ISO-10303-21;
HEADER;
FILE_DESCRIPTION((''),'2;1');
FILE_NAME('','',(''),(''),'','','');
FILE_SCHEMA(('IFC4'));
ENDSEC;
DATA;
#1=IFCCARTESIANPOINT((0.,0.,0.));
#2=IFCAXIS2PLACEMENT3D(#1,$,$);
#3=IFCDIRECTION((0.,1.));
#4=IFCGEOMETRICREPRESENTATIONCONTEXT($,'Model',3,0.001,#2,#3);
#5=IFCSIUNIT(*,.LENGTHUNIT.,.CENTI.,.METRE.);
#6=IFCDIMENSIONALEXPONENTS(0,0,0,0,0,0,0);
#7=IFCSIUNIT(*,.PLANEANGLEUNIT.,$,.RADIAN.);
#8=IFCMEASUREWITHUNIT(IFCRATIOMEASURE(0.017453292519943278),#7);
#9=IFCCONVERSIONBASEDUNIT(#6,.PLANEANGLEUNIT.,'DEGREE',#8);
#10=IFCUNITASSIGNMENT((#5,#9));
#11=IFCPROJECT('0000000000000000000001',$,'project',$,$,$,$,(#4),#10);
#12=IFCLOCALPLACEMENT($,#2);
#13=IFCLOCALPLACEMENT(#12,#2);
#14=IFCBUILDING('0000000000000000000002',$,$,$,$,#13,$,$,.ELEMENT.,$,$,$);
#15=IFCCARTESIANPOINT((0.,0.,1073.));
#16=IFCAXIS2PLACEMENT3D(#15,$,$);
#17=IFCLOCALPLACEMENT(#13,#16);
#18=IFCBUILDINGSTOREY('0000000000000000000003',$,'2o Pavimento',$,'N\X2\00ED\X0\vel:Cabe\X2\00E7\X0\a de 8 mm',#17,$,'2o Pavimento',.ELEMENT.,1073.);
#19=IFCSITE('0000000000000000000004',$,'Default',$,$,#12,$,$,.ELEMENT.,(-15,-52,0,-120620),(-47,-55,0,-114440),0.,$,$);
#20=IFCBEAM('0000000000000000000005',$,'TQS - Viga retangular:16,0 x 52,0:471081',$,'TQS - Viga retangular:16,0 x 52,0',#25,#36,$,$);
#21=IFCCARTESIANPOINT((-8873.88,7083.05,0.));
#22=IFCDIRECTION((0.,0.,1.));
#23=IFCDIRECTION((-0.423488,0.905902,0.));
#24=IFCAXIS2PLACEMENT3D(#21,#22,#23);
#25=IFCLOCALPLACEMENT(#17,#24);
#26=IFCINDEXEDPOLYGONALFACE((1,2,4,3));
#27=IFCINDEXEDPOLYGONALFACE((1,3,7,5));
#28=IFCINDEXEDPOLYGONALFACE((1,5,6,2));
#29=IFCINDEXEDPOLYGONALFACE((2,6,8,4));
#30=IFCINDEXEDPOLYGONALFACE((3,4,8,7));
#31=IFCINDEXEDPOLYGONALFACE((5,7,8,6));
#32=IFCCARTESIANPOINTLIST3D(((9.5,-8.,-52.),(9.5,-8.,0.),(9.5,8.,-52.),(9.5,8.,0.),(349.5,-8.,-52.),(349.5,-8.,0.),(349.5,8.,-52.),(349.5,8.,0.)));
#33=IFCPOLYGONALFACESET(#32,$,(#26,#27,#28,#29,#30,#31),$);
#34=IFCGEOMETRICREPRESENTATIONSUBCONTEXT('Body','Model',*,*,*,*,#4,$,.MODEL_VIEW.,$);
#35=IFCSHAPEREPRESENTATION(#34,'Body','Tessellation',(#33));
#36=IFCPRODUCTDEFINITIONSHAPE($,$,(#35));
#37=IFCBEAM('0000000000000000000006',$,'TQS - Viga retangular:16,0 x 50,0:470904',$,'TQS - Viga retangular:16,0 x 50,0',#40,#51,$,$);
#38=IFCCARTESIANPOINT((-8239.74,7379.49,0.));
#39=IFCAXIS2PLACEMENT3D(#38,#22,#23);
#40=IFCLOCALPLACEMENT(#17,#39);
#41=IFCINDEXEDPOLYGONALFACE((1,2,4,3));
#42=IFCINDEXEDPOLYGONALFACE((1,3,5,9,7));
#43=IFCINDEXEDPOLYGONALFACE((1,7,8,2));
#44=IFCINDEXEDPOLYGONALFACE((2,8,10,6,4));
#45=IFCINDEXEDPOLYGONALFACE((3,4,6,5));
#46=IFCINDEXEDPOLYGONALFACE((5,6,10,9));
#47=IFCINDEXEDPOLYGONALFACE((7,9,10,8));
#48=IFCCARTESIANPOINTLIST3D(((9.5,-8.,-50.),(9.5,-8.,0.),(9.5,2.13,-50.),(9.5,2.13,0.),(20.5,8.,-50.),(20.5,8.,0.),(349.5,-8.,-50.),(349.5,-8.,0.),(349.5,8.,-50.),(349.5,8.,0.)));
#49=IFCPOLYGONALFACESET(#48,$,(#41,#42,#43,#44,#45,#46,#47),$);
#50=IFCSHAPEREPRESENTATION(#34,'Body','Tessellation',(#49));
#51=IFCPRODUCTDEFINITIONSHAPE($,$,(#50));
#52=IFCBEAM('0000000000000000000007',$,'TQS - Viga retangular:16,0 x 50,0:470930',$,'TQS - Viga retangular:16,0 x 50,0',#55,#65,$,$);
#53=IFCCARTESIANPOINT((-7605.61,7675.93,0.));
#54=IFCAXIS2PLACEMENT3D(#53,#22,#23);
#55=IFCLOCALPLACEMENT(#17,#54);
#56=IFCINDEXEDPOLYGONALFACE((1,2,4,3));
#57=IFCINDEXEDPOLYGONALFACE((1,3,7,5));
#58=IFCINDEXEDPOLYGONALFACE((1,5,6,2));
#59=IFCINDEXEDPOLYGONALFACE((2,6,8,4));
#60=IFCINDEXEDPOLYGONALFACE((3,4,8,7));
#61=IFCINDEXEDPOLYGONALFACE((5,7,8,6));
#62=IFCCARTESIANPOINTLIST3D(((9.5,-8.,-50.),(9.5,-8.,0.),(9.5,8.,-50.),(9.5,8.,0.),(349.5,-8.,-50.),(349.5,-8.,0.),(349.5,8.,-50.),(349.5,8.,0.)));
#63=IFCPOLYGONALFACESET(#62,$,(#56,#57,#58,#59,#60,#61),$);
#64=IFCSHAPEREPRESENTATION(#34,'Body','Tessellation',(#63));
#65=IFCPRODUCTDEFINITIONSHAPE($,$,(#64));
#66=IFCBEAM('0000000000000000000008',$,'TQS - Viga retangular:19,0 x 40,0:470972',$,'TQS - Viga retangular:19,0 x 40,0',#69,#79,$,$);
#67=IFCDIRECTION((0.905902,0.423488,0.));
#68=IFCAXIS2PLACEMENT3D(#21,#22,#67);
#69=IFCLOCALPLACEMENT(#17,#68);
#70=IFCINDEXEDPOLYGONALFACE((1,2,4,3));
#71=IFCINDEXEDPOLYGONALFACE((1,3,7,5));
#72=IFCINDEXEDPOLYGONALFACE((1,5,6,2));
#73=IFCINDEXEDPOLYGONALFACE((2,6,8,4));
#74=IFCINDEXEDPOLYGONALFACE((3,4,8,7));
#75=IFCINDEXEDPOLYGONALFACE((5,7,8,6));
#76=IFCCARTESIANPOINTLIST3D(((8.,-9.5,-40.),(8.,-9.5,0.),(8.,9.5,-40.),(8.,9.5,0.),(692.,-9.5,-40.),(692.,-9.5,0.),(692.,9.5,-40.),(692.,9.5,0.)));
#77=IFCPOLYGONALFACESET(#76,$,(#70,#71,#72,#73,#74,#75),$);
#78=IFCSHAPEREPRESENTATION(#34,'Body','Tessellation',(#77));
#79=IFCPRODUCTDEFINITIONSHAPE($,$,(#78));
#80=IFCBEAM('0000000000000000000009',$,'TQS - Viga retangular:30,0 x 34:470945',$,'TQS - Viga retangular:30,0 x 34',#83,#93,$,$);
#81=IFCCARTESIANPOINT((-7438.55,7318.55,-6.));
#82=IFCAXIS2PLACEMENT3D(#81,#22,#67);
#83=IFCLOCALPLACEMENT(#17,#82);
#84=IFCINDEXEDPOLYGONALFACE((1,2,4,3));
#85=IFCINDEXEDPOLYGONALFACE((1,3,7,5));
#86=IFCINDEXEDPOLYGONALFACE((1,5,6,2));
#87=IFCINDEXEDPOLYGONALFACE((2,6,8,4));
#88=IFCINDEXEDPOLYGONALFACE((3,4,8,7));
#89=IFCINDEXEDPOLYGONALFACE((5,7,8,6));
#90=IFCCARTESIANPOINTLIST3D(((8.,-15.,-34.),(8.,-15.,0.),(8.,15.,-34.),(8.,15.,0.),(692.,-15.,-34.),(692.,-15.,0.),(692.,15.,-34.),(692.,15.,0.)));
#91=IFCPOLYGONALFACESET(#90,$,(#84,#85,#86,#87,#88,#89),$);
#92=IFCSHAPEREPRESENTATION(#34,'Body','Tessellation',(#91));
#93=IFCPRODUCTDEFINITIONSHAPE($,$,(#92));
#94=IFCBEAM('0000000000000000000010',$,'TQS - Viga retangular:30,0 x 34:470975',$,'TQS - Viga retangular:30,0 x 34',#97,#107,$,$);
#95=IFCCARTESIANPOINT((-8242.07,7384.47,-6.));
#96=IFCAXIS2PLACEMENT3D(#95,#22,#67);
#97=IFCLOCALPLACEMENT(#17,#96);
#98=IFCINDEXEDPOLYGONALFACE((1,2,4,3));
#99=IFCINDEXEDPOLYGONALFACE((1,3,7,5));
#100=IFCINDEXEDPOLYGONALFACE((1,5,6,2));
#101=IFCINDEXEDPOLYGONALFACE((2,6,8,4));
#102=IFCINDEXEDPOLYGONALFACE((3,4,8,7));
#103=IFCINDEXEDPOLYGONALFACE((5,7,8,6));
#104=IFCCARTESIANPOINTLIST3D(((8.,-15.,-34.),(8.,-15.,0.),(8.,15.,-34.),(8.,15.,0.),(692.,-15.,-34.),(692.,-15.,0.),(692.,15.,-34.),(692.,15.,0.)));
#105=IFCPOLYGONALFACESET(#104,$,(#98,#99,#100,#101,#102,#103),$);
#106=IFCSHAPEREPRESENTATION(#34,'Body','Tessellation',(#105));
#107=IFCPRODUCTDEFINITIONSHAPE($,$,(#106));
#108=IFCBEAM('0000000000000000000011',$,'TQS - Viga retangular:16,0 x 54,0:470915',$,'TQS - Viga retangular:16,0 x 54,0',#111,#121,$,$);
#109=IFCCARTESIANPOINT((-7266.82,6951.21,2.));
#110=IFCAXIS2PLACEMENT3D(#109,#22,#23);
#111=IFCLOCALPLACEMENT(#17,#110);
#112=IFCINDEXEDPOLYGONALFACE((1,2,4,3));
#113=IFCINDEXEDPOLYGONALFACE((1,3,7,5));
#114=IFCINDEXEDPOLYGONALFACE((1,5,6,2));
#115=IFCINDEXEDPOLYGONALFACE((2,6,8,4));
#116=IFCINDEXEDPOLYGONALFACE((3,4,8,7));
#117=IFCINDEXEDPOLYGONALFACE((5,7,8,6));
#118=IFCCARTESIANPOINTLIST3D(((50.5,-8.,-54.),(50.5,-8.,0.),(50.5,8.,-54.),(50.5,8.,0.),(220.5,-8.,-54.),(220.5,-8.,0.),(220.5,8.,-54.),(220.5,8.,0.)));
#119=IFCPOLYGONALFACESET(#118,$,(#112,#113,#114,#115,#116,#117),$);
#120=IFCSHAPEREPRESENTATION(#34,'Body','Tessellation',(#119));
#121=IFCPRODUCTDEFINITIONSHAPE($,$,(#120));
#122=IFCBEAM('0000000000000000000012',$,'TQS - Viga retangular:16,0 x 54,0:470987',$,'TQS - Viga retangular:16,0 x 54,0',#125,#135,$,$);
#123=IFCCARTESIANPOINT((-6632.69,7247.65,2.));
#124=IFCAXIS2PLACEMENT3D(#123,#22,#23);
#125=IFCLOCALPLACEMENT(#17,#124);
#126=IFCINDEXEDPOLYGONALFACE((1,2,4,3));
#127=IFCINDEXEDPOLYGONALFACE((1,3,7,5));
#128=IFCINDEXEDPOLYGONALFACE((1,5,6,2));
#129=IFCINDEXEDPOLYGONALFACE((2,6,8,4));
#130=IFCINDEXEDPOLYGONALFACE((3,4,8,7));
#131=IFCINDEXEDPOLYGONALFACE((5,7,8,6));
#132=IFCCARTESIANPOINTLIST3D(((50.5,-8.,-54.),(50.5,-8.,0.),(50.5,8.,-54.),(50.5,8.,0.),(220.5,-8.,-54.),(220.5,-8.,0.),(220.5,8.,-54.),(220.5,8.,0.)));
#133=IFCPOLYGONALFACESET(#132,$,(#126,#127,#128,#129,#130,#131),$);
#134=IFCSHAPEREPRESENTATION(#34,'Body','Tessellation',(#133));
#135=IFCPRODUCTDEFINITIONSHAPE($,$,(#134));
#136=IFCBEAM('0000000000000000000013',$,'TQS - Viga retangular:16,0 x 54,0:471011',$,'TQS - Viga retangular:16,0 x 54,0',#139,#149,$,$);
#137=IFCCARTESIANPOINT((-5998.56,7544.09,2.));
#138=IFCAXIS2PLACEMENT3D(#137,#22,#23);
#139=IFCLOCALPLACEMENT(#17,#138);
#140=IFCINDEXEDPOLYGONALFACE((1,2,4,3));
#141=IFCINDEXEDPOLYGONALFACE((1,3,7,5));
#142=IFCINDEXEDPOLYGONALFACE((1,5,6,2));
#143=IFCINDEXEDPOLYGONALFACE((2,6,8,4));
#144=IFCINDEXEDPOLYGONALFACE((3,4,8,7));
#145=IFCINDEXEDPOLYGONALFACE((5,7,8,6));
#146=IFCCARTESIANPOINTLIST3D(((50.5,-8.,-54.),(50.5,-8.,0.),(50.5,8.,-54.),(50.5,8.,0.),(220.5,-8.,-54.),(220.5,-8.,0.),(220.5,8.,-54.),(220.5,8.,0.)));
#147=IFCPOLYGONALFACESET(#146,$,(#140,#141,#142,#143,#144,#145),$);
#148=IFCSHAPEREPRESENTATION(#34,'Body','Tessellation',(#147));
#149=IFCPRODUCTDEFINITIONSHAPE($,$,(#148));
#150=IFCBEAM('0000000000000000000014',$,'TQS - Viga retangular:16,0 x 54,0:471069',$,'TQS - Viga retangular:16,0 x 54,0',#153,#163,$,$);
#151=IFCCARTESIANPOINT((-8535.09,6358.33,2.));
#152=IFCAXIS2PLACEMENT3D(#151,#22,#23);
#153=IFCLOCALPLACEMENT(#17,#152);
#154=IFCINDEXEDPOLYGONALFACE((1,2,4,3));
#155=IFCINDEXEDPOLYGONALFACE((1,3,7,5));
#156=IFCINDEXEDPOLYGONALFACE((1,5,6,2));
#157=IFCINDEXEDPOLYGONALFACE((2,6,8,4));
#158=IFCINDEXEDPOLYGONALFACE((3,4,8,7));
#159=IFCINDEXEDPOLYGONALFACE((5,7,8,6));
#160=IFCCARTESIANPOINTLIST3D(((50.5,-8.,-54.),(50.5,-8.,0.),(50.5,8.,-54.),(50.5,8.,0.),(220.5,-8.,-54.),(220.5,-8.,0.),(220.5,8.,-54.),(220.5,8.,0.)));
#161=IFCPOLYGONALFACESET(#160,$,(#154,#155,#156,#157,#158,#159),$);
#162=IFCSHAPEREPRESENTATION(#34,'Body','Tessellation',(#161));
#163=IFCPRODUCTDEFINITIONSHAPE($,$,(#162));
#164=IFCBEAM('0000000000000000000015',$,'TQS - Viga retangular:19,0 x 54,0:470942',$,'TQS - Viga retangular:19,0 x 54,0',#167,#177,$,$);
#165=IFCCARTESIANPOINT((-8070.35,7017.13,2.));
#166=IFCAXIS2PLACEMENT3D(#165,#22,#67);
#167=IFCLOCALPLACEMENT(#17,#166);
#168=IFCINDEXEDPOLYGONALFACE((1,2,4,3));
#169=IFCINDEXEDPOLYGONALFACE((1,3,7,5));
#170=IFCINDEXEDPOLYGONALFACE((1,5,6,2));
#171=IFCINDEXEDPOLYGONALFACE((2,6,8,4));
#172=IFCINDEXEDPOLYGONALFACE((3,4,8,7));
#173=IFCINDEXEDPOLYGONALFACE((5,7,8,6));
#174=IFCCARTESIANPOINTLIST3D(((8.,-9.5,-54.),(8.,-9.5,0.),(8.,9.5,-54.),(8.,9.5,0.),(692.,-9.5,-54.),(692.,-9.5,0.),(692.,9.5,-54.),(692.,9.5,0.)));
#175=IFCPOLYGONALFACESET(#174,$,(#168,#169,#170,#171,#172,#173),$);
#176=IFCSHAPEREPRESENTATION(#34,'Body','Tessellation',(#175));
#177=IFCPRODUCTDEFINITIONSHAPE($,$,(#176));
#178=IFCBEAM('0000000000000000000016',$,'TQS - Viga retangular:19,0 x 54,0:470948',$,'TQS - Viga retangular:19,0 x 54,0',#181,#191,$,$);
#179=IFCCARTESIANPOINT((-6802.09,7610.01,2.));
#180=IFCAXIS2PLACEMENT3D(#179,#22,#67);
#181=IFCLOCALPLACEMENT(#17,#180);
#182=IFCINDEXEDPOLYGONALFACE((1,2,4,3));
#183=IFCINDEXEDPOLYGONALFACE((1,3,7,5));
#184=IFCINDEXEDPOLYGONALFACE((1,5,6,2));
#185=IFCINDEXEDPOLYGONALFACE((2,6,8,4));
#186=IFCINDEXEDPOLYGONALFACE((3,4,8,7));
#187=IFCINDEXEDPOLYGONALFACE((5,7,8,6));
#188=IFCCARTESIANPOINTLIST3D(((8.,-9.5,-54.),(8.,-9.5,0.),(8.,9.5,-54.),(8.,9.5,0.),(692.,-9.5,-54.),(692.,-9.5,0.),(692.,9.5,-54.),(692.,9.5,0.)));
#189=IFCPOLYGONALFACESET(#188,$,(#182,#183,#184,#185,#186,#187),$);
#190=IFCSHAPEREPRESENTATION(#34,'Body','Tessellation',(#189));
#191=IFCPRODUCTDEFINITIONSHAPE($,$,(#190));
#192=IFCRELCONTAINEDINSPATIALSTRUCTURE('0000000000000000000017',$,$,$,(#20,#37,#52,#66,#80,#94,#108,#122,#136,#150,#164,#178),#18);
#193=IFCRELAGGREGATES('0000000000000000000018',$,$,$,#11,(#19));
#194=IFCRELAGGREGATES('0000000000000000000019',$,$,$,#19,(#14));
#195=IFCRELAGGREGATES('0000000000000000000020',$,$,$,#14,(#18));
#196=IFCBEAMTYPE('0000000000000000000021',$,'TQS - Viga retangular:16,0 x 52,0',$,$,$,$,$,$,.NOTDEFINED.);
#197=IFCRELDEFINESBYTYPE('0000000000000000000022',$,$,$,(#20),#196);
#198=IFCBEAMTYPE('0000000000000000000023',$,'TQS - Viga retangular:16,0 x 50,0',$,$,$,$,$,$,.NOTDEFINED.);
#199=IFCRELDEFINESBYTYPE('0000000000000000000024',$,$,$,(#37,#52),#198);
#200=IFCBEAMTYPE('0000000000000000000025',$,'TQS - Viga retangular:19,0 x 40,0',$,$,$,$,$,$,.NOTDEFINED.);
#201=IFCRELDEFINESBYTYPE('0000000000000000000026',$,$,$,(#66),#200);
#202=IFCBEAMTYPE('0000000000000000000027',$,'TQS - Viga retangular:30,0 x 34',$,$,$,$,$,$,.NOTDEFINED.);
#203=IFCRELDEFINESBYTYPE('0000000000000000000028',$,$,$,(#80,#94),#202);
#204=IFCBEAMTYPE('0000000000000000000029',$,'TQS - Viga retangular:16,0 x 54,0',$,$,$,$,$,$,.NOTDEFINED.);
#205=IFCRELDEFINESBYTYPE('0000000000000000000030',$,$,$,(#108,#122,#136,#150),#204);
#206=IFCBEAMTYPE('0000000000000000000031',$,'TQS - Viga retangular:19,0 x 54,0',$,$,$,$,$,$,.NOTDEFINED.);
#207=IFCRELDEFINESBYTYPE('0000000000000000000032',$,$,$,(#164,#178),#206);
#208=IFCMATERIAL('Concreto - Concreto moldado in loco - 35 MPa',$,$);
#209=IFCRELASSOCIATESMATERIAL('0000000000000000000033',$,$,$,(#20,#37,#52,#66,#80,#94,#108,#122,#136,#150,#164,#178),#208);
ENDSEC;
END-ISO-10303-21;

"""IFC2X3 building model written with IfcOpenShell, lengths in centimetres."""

from ifc_helpers import new_model, entity, si_unit, converted_unit, direction, frame, frame_2d, origin, place, context, subcontext, project, spatial, rectangle, extrude, clip, halfspace, material, type_object, element, save


model = new_model("IFC2X3")

# Units and contexts
model_context = context("Model", 3, precision=0.001, world=origin(), true_north=direction((0.0, 1.0)))
body_context = subcontext(model_context, "Body", "Model", "MODEL_VIEW")
ifc_project = project(units=[si_unit("LENGTHUNIT", "METRE", prefix="CENTI"), converted_unit("PLANEANGLEUNIT", "DEGREE", entity("IfcRatioMeasure", 0.017453292519943278), si_unit("PLANEANGLEUNIT", "RADIAN"), dimensions=[0, 0, 0, 0, 0, 0, 0])], contexts=[model_context])

# Site, building, storey
site_placement = place(None, origin())
site = spatial("IfcSite", under=ifc_project, at=site_placement, Name="Default", CompositionType="ELEMENT", RefLatitude=(-15, -52, 0, -120620), RefLongitude=(-47, -55, 0, -114440), RefElevation=0.0)
building_placement = place(site_placement, origin())
building = spatial("IfcBuilding", under=site, at=building_placement, CompositionType="ELEMENT")
storey_placement = place(building_placement, frame((0.0, 0.0, 1073.0)))
storey = spatial("IfcBuildingStorey", under=building, at=storey_placement, Name="2o Pavimento", ObjectType="Nível:Cabeça de 8 mm", LongName="2o Pavimento", CompositionType="ELEMENT", Elevation=1073.0)

# Beams
ifc_material_1 = material(Name="Concreto - Concreto moldado in loco - 35 MPa")
beam_type_1 = type_object("IfcBeamType", Name="TQS - Viga retangular:16,0 x 52,0", PredefinedType="NOTDEFINED")
beam_1_placement = place(storey_placement, frame((-8873.88, 7083.05, 0.0), z_axis=(0.0, 0.0, 1.0), x_axis=(-0.423488, 0.905902, 0.0)))
element("IfcBeam", 1, at=beam_1_placement, inside=storey, type_object=beam_type_1, material=ifc_material_1, Name="TQS - Viga retangular:16,0 x 52,0:471081", ObjectType="TQS - Viga retangular:16,0 x 52,0", context=body_context, shape_type="SweptSolid", body=[
    extrude(rectangle(XDim=52.0, YDim=16.0, at=frame_2d((0.0, 0.0), x_axis=(1.0, 0.0))), frame((9.5, 0.0, -26.0), z_axis=(1.0, 0.0, 0.0), x_axis=(0.0, 0.0, -1.0)), (0.0, 0.0, 1.0), 340.0),
])
beam_type_2 = type_object("IfcBeamType", Name="TQS - Viga retangular:16,0 x 50,0", PredefinedType="NOTDEFINED")
beam_2_placement = place(storey_placement, frame((-8239.74, 7379.49, 0.0), z_axis=(0.0, 0.0, 1.0), x_axis=(-0.423488, 0.905902, 0.0)))
element("IfcBeam", 2, at=beam_2_placement, inside=storey, type_object=beam_type_2, material=ifc_material_1, Name="TQS - Viga retangular:16,0 x 50,0:470904", ObjectType="TQS - Viga retangular:16,0 x 50,0", context=body_context, shape_type="SweptSolid", body=[
    clip(extrude(rectangle(XDim=50.0, YDim=16.0, at=frame_2d((0.0, 0.0), x_axis=(1.0, 0.0))), frame((9.5, 0.0, -25.0), z_axis=(1.0, 0.0, 0.0), x_axis=(0.0, 0.0, -1.0)), (0.0, 0.0, 1.0), 340.0), halfspace(frame((-9.5, -8.0, 0.0), z_axis=(-0.470588, 0.882353, 0.0), x_axis=(-0.882353, -0.470588, 0.0)), False)),
])
beam_3_placement = place(storey_placement, frame((-7605.61, 7675.93, 0.0), z_axis=(0.0, 0.0, 1.0), x_axis=(-0.423488, 0.905902, 0.0)))
element("IfcBeam", 3, at=beam_3_placement, inside=storey, type_object=beam_type_2, material=ifc_material_1, Name="TQS - Viga retangular:16,0 x 50,0:470930", ObjectType="TQS - Viga retangular:16,0 x 50,0", context=body_context, shape_type="SweptSolid", body=[
    extrude(rectangle(XDim=50.0, YDim=16.0, at=frame_2d((0.0, 0.0), x_axis=(1.0, 0.0))), frame((9.5, 0.0, -25.0), z_axis=(1.0, 0.0, 0.0), x_axis=(0.0, 0.0, -1.0)), (0.0, 0.0, 1.0), 340.0),
])
beam_type_3 = type_object("IfcBeamType", Name="TQS - Viga retangular:19,0 x 40,0", PredefinedType="NOTDEFINED")
beam_4_placement = place(storey_placement, frame((-8873.88, 7083.05, 0.0), z_axis=(0.0, 0.0, 1.0), x_axis=(0.905902, 0.423488, 0.0)))
element("IfcBeam", 4, at=beam_4_placement, inside=storey, type_object=beam_type_3, material=ifc_material_1, Name="TQS - Viga retangular:19,0 x 40,0:470972", ObjectType="TQS - Viga retangular:19,0 x 40,0", context=body_context, shape_type="SweptSolid", body=[
    extrude(rectangle(XDim=40.0, YDim=19.0, at=frame_2d((0.0, 0.0), x_axis=(1.0, 0.0))), frame((8.0, 0.0, -20.0), z_axis=(1.0, 0.0, 0.0), x_axis=(0.0, 0.0, -1.0)), (0.0, 0.0, 1.0), 684.0),
])
beam_type_4 = type_object("IfcBeamType", Name="TQS - Viga retangular:30,0 x 34", PredefinedType="NOTDEFINED")
beam_5_placement = place(storey_placement, frame((-7438.55, 7318.55, -6.0), z_axis=(0.0, 0.0, 1.0), x_axis=(0.905902, 0.423488, 0.0)))
element("IfcBeam", 5, at=beam_5_placement, inside=storey, type_object=beam_type_4, material=ifc_material_1, Name="TQS - Viga retangular:30,0 x 34:470945", ObjectType="TQS - Viga retangular:30,0 x 34", context=body_context, shape_type="SweptSolid", body=[
    extrude(rectangle(XDim=34.0, YDim=30.0, at=frame_2d((0.0, 0.0), x_axis=(1.0, 0.0))), frame((8.0, 0.0, -17.0), z_axis=(1.0, 0.0, 0.0), x_axis=(0.0, 0.0, -1.0)), (0.0, 0.0, 1.0), 684.0),
])
beam_6_placement = place(storey_placement, frame((-8242.07, 7384.47, -6.0), z_axis=(0.0, 0.0, 1.0), x_axis=(0.905902, 0.423488, 0.0)))
element("IfcBeam", 6, at=beam_6_placement, inside=storey, type_object=beam_type_4, material=ifc_material_1, Name="TQS - Viga retangular:30,0 x 34:470975", ObjectType="TQS - Viga retangular:30,0 x 34", context=body_context, shape_type="SweptSolid", body=[
    extrude(rectangle(XDim=34.0, YDim=30.0, at=frame_2d((0.0, 0.0), x_axis=(1.0, 0.0))), frame((8.0, 0.0, -17.0), z_axis=(1.0, 0.0, 0.0), x_axis=(0.0, 0.0, -1.0)), (0.0, 0.0, 1.0), 684.0),
])
beam_type_5 = type_object("IfcBeamType", Name="TQS - Viga retangular:16,0 x 54,0", PredefinedType="NOTDEFINED")
beam_7_placement = place(storey_placement, frame((-7266.82, 6951.21, 2.0), z_axis=(0.0, 0.0, 1.0), x_axis=(-0.423488, 0.905902, 0.0)))
element("IfcBeam", 7, at=beam_7_placement, inside=storey, type_object=beam_type_5, material=ifc_material_1, Name="TQS - Viga retangular:16,0 x 54,0:470915", ObjectType="TQS - Viga retangular:16,0 x 54,0", context=body_context, shape_type="SweptSolid", body=[
    extrude(rectangle(XDim=54.0, YDim=16.0, at=frame_2d((0.0, 0.0), x_axis=(1.0, 0.0))), frame((50.5, 0.0, -27.0), z_axis=(1.0, 0.0, 0.0), x_axis=(0.0, 0.0, -1.0)), (0.0, 0.0, 1.0), 170.0),
])
beam_8_placement = place(storey_placement, frame((-6632.69, 7247.65, 2.0), z_axis=(0.0, 0.0, 1.0), x_axis=(-0.423488, 0.905902, 0.0)))
element("IfcBeam", 8, at=beam_8_placement, inside=storey, type_object=beam_type_5, material=ifc_material_1, Name="TQS - Viga retangular:16,0 x 54,0:470987", ObjectType="TQS - Viga retangular:16,0 x 54,0", context=body_context, shape_type="SweptSolid", body=[
    extrude(rectangle(XDim=54.0, YDim=16.0, at=frame_2d((0.0, 0.0), x_axis=(1.0, 0.0))), frame((50.5, 0.0, -27.0), z_axis=(1.0, 0.0, 0.0), x_axis=(0.0, 0.0, -1.0)), (0.0, 0.0, 1.0), 170.0),
])
beam_9_placement = place(storey_placement, frame((-5998.56, 7544.09, 2.0), z_axis=(0.0, 0.0, 1.0), x_axis=(-0.423488, 0.905902, 0.0)))
element("IfcBeam", 9, at=beam_9_placement, inside=storey, type_object=beam_type_5, material=ifc_material_1, Name="TQS - Viga retangular:16,0 x 54,0:471011", ObjectType="TQS - Viga retangular:16,0 x 54,0", context=body_context, shape_type="SweptSolid", body=[
    extrude(rectangle(XDim=54.0, YDim=16.0, at=frame_2d((0.0, 0.0), x_axis=(1.0, 0.0))), frame((50.5, 0.0, -27.0), z_axis=(1.0, 0.0, 0.0), x_axis=(0.0, 0.0, -1.0)), (0.0, 0.0, 1.0), 170.0),
])
beam_10_placement = place(storey_placement, frame((-8535.09, 6358.33, 2.0), z_axis=(0.0, 0.0, 1.0), x_axis=(-0.423488, 0.905902, 0.0)))
element("IfcBeam", 10, at=beam_10_placement, inside=storey, type_object=beam_type_5, material=ifc_material_1, Name="TQS - Viga retangular:16,0 x 54,0:471069", ObjectType="TQS - Viga retangular:16,0 x 54,0", context=body_context, shape_type="SweptSolid", body=[
    extrude(rectangle(XDim=54.0, YDim=16.0, at=frame_2d((0.0, 0.0), x_axis=(1.0, 0.0))), frame((50.5, 0.0, -27.0), z_axis=(1.0, 0.0, 0.0), x_axis=(0.0, 0.0, -1.0)), (0.0, 0.0, 1.0), 170.0),
])
beam_type_6 = type_object("IfcBeamType", Name="TQS - Viga retangular:19,0 x 54,0", PredefinedType="NOTDEFINED")
beam_11_placement = place(storey_placement, frame((-8070.35, 7017.13, 2.0), z_axis=(0.0, 0.0, 1.0), x_axis=(0.905902, 0.423488, 0.0)))
element("IfcBeam", 11, at=beam_11_placement, inside=storey, type_object=beam_type_6, material=ifc_material_1, Name="TQS - Viga retangular:19,0 x 54,0:470942", ObjectType="TQS - Viga retangular:19,0 x 54,0", context=body_context, shape_type="SweptSolid", body=[
    extrude(rectangle(XDim=54.0, YDim=19.0, at=frame_2d((0.0, 0.0), x_axis=(1.0, 0.0))), frame((8.0, 0.0, -27.0), z_axis=(1.0, 0.0, 0.0), x_axis=(0.0, 0.0, -1.0)), (0.0, 0.0, 1.0), 684.0),
])
beam_12_placement = place(storey_placement, frame((-6802.09, 7610.01, 2.0), z_axis=(0.0, 0.0, 1.0), x_axis=(0.905902, 0.423488, 0.0)))
element("IfcBeam", 12, at=beam_12_placement, inside=storey, type_object=beam_type_6, material=ifc_material_1, Name="TQS - Viga retangular:19,0 x 54,0:470948", ObjectType="TQS - Viga retangular:19,0 x 54,0", context=body_context, shape_type="SweptSolid", body=[
    extrude(rectangle(XDim=54.0, YDim=19.0, at=frame_2d((0.0, 0.0), x_axis=(1.0, 0.0))), frame((8.0, 0.0, -27.0), z_axis=(1.0, 0.0, 0.0), x_axis=(0.0, 0.0, -1.0)), (0.0, 0.0, 1.0), 684.0),
])

save(model, "model.ifc")
